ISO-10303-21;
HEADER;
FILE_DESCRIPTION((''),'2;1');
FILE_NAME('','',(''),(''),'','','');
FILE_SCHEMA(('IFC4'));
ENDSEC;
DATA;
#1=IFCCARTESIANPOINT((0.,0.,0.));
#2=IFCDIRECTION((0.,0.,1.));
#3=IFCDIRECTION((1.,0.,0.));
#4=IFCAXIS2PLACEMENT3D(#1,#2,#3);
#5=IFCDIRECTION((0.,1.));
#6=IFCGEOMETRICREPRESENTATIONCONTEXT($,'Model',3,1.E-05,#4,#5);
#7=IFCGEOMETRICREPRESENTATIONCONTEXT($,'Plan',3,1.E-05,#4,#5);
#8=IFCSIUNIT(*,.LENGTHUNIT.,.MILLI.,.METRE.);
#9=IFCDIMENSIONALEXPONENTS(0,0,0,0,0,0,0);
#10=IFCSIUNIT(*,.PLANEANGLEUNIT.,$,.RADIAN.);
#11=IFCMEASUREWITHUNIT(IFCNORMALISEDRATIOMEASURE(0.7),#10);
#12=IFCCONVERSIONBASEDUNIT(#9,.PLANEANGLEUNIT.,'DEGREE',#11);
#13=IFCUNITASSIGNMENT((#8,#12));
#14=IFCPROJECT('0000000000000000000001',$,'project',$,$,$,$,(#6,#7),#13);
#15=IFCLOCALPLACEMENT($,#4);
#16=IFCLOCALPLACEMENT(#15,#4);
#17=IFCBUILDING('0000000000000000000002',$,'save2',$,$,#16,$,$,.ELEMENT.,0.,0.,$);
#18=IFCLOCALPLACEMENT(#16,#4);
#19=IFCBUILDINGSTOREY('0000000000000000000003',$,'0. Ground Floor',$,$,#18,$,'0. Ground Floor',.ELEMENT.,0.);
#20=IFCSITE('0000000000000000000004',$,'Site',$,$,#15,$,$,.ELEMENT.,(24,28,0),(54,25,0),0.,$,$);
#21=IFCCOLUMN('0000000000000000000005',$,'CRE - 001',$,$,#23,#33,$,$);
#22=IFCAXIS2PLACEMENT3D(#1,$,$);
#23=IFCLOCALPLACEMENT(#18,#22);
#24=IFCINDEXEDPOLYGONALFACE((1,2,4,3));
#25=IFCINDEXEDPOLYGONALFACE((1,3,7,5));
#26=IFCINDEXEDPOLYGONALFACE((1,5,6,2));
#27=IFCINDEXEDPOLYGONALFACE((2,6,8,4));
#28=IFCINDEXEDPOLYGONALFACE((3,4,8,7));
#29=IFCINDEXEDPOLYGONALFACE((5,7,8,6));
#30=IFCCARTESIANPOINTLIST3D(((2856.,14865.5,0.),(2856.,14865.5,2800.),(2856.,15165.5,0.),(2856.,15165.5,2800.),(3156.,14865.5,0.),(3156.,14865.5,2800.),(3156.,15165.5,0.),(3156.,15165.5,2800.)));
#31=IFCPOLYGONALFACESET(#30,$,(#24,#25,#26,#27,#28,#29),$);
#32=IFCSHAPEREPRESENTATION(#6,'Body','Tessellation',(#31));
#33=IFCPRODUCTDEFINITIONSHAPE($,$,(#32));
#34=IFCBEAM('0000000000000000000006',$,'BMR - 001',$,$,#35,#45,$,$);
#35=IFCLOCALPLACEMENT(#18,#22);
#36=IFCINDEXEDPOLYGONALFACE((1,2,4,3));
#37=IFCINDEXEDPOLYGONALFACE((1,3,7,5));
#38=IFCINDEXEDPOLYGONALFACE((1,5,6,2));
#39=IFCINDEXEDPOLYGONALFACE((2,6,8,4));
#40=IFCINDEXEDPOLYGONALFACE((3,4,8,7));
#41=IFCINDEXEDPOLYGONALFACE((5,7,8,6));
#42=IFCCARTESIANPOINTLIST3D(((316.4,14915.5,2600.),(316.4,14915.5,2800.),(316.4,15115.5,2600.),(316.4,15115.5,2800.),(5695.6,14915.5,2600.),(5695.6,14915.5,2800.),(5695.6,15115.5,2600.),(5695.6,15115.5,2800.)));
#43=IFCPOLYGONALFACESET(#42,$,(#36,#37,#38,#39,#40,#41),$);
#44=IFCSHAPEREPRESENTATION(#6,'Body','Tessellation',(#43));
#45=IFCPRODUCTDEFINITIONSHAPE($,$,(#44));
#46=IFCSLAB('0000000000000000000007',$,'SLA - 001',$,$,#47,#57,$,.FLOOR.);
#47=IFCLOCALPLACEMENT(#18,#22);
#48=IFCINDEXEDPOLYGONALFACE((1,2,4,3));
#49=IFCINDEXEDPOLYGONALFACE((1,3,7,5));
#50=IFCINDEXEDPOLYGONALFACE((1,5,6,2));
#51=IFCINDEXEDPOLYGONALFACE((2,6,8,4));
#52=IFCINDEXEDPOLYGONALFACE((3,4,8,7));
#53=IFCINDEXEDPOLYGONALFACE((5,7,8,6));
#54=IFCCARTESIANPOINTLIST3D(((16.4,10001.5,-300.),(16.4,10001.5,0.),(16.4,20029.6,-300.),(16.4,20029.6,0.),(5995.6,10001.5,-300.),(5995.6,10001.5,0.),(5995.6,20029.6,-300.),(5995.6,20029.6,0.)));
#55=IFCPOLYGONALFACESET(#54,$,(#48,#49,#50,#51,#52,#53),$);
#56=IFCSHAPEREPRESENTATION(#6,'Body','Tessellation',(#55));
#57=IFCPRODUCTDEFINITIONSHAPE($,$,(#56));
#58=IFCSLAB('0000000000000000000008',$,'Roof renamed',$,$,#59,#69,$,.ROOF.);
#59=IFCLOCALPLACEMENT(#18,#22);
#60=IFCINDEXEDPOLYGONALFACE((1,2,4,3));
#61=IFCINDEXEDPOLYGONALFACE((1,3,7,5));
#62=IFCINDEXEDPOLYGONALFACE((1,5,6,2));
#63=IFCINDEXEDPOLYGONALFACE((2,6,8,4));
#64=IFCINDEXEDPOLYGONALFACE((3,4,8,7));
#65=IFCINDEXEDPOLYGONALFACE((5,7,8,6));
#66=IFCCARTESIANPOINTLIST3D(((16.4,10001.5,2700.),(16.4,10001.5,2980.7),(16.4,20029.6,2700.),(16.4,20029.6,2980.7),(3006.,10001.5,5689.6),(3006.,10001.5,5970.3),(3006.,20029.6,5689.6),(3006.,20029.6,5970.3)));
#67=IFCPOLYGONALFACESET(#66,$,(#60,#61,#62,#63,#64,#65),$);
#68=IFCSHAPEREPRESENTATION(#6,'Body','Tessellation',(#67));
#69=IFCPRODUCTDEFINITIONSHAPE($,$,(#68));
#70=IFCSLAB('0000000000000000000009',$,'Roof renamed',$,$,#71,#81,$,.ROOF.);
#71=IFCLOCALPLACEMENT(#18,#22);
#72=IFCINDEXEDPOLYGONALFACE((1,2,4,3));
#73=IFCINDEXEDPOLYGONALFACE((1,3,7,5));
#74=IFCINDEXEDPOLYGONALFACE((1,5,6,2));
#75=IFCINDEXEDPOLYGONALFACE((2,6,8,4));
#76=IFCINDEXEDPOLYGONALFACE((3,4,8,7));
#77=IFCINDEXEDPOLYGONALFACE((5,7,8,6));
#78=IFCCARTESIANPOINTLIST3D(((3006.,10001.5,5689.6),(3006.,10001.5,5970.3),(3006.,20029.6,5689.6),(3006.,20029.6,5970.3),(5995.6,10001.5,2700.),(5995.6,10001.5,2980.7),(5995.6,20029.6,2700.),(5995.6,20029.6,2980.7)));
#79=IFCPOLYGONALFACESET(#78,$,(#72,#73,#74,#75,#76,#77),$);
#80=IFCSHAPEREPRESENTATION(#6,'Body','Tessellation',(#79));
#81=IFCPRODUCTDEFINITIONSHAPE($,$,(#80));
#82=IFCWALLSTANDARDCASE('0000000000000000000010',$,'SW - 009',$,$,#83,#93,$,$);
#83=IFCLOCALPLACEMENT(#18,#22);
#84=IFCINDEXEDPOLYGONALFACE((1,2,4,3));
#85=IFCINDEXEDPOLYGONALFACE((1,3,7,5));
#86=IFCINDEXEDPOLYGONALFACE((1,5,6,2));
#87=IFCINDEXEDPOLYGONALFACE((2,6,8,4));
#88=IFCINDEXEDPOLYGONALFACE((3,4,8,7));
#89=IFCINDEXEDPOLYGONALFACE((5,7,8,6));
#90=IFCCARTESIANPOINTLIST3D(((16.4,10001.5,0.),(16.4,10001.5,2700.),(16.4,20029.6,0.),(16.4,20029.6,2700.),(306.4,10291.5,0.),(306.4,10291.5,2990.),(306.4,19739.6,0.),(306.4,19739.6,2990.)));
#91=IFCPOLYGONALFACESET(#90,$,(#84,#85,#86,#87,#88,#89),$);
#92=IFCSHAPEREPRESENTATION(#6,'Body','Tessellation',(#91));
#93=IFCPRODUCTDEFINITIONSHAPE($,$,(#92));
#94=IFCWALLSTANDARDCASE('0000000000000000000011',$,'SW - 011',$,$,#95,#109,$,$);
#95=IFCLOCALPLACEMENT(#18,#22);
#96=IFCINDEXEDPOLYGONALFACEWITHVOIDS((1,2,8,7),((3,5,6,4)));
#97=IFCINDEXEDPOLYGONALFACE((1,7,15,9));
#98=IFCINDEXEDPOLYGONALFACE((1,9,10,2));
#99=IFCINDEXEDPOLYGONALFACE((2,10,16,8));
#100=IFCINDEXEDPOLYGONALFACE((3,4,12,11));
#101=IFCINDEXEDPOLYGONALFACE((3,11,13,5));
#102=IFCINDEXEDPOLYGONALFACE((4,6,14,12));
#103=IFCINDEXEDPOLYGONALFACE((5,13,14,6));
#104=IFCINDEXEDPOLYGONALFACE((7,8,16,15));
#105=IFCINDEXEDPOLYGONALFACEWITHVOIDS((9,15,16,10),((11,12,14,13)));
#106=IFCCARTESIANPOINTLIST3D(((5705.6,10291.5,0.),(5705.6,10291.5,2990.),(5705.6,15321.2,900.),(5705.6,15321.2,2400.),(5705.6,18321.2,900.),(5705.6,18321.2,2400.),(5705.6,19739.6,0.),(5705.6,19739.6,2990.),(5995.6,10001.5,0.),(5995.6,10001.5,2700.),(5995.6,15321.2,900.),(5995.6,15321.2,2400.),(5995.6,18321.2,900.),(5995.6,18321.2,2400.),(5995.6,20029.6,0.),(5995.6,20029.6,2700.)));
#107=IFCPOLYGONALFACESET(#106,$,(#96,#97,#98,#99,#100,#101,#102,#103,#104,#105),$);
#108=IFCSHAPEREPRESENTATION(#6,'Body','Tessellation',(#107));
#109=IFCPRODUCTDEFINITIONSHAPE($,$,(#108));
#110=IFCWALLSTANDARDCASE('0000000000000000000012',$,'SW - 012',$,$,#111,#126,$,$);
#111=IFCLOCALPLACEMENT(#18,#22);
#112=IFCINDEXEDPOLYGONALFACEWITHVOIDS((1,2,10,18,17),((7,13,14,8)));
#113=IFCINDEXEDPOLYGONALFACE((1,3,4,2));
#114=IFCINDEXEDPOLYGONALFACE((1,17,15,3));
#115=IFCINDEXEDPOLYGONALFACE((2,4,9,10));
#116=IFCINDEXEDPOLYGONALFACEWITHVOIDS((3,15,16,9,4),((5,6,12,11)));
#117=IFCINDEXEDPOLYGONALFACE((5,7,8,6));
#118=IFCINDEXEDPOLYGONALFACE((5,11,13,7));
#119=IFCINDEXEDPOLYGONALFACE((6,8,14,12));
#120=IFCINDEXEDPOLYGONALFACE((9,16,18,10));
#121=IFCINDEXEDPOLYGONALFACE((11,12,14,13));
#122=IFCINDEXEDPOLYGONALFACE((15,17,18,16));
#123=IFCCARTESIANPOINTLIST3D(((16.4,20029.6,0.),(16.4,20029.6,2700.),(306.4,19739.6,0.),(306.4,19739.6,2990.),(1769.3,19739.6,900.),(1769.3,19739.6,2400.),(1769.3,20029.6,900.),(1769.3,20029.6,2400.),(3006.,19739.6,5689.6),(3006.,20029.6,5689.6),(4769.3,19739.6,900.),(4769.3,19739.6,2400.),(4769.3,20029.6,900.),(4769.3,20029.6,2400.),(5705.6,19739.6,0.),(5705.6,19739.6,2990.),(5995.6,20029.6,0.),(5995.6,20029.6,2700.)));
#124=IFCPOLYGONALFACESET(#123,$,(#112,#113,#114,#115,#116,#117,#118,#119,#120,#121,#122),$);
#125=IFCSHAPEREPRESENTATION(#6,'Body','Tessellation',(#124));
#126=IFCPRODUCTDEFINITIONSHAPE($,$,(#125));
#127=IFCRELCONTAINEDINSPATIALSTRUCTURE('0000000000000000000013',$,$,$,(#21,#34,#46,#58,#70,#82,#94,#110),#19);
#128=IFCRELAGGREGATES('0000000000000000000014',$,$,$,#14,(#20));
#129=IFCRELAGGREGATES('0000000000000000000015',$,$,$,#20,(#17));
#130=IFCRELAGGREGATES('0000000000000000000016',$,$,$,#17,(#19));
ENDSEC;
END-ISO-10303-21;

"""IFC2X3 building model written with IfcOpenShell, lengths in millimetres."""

from ifc_helpers import new_model, entity, si_unit, converted_unit, direction, frame, frame_2d, origin_with_axes, origin_2d_with_axis, place, context, project, spatial, polyline, rectangle, outline, extrude, clip, halfspace, bounded_halfspace, element, save


model = new_model("IFC2X3")

# Units and contexts
model_context_1 = context("Model", 3, precision=1e-05, world=origin_with_axes(), true_north=direction((0.0, 1.0)))
model_context_2 = context("Model", 3, precision=1e-05, world=origin_with_axes(), true_north=direction((0.0, 1.0)))
plan_context = context("Plan", 3, precision=1e-05, world=origin_with_axes(), true_north=direction((0.0, 1.0)))
ifc_project = project(units=[si_unit("LENGTHUNIT", "METRE", prefix="MILLI"), converted_unit("PLANEANGLEUNIT", "DEGREE", entity("IfcNormalisedRatioMeasure", 0.7), si_unit("PLANEANGLEUNIT", "RADIAN"), dimensions=[0, 0, 0, 0, 0, 0, 0])], contexts=[model_context_2, plan_context])

# Site, building, storey
site_placement = place(None, origin_with_axes())
site = spatial("IfcSite", under=ifc_project, at=site_placement, Name="Site", CompositionType="ELEMENT", RefLatitude=(24, 28, 0), RefLongitude=(54, 25, 0), RefElevation=0.0)
building_placement = place(site_placement, origin_with_axes())
building = spatial("IfcBuilding", under=site, at=building_placement, Name="save2", CompositionType="ELEMENT", ElevationOfRefHeight=0.0, ElevationOfTerrain=0.0)
storey_placement = place(building_placement, origin_with_axes())
storey = spatial("IfcBuildingStorey", under=building, at=storey_placement, Name="0. Ground Floor", LongName="0. Ground Floor", CompositionType="ELEMENT", Elevation=0.0)

# Column
column_placement = place(storey_placement, frame((3006.0, 15015.5, 0.0), z_axis=(0.0, 0.0, 1.0), x_axis=(1.0, 0.0, 0.0)))
element("IfcColumn", 1, at=column_placement, inside=storey, Name="CRE - 001", context=model_context_2, shape_type="SweptSolid", body=[
    extrude(rectangle(XDim=300.0, YDim=300.0, at=origin_2d_with_axis()), origin_with_axes(), (0.0, 0.0, 1.0), 2800.0),
])

# Beam
beam_placement = place(storey_placement, frame((316.4, 15015.5, 2800.0), z_axis=(0.0, 0.0, 1.0), x_axis=(0.0, -1.0, 0.0)))
element("IfcBeam", 2, at=beam_placement, inside=storey, Name="BMR - 001", context=model_context_2, shape_type="SweptSolid", body=[
    extrude(rectangle(XDim=200.0, YDim=200.0, at=frame_2d((-100.0, 0.0), x_axis=(1.0, 0.0))), frame((0.0, 0.0, 0.0), z_axis=(0.0, 1.0, 0.0), x_axis=(0.0, 0.0, 1.0)), (0.0, 0.0, 1.0), 5379.1),
])

# Slabs
slab_1_placement = place(storey_placement, frame((16.4, 20029.6, -300.0), z_axis=(0.0, 0.0, 1.0), x_axis=(1.0, 0.0, 0.0)))
element("IfcSlab", 3, at=slab_1_placement, inside=storey, Name="SLA - 001", PredefinedType="FLOOR", context=model_context_2, shape_type="SweptSolid", body=[
    extrude(outline(polyline([(0.0, 0.0), (5979.1, 0.0), (5979.1, -10028.0), (0.0, -10028.0)])), origin_with_axes(), (0.0, 0.0, 1.0), 300.0),
])
slab_2_placement = place(storey_placement, frame((16.4, 20029.6, 2700.0), z_axis=(-0.707107, 0.0, 0.707107), x_axis=(0.0, -1.0, 0.0)))
element("IfcSlab", 4, at=slab_2_placement, inside=storey, Name="Roof renamed", PredefinedType="ROOF", context=model_context_2, shape_type="SweptSolid", body=[
    extrude(outline(polyline([(0.0, 0.0), (0.0, 4227.9), (10028.0, 4227.9), (10028.0, 0.0)])), origin_with_axes(), (0.0, 0.707107, 0.707107), 280.7),
])
slab_3_placement = place(storey_placement, frame((5995.6, 10001.5, 2700.0), z_axis=(0.707107, 0.0, 0.707107), x_axis=(0.0, 1.0, 0.0)))
element("IfcSlab", 5, at=slab_3_placement, inside=storey, Name="Roof renamed", PredefinedType="ROOF", context=model_context_2, shape_type="SweptSolid", body=[
    extrude(outline(polyline([(0.0, 0.0), (10028.0, 0.0), (10028.0, 4227.9), (0.0, 4227.9)])), origin_with_axes(), (0.0, 0.707107, 0.707107), 280.7),
])

# Wall
wall_1_placement = place(storey_placement, frame((16.4, 20029.6, 0.0), z_axis=(0.0, 0.0, 1.0), x_axis=(0.0, -1.0, 0.0)))
element("IfcWallStandardCase", 6, at=wall_1_placement, inside=storey, Name="SW - 009", context=model_context_2, shape_type="Clipping", body=[
    clip(extrude(outline(polyline([(0.0, 0.0), (10028.0, 0.0), (9738.0, 290.0), (290.0, 290.0)])), origin_with_axes(), (0.0, 0.0, 1.0), 6000.0), halfspace(frame((0.0, -1350.0, 1350.0), z_axis=(0.0, 0.707107, -0.707107), x_axis=(0.0, 0.707107, 0.707107)), True)),
])

# Walls, openings
wall_2_placement = place(storey_placement, frame((5995.6, 10001.5, 0.0), z_axis=(0.0, 0.0, 1.0), x_axis=(0.0, 1.0, 0.0)))
wall_2 = element("IfcWallStandardCase", 7, at=wall_2_placement, inside=storey, Name="SW - 011", context=model_context_2, shape_type="Clipping", body=[
    clip(extrude(outline(polyline([(0.0, 0.0), (10028.0, 0.0), (9738.0, 290.0), (290.0, 290.0)])), origin_with_axes(), (0.0, 0.0, 1.0), 6000.0), halfspace(frame((0.0, -1350.0, 1350.0), z_axis=(0.0, 0.707107, -0.707107), x_axis=(0.0, 0.707107, 0.707107)), True)),
])
opening_1_placement = place(wall_2_placement, frame((6819.7, 0.0, 900.0), z_axis=(0.0, 0.0, 1.0), x_axis=(1.0, 0.0, 0.0)))
element("IfcOpeningElement", 8, at=opening_1_placement, cuts=wall_2, ObjectType="Opening", context=model_context_2, shape_type="SweptSolid", body=[
    extrude(rectangle(XDim=3000.0, YDim=1500.0, at=frame_2d((0.0, 750.0), x_axis=(1.0, 0.0))), frame((0.0, 0.0, 0.0), z_axis=(0.0, 1.0, 0.0), x_axis=(-1.0, 0.0, 0.0)), (0.0, 0.0, 1.0), 290.0),
])
wall_3_placement = place(storey_placement, frame((5995.6, 20029.6, 0.0), z_axis=(0.0, 0.0, 1.0), x_axis=(-1.0, 0.0, 0.0)))
wall_3 = element("IfcWallStandardCase", 9, at=wall_3_placement, inside=storey, Name="SW - 012", context=model_context_2, shape_type="Clipping", body=[
    clip(clip(extrude(outline(polyline([(0.0, 0.0), (5979.1, 0.0), (5689.1, 290.0), (290.0, 290.0)])), origin_with_axes(), (0.0, 0.0, 1.0), 6000.0), bounded_halfspace(frame((4339.6, 0.0, 4339.6), z_axis=(-0.707107, 0.0, -0.707107), x_axis=(0.0, 1.0, 0.0)), True, origin_with_axes(), polyline([(2989.6, -145.0), (2989.6, 435.0), (5989.1, 435.0), (5989.1, -145.0), (2989.6, -145.0)]))), bounded_halfspace(frame((-1350.0, 0.0, 1350.0), z_axis=(0.707107, 0.0, -0.707107), x_axis=(0.0, 1.0, 0.0)), True, origin_with_axes(), polyline([(2989.6, -145.0), (2989.6, 435.0), (-10.0, 435.0), (-10.0, -145.0), (2989.6, -145.0)]))),
])
placement_1 = place(None, origin_with_axes())
placement_2 = place(placement_1, origin_with_axes())
placement_3 = place(placement_2, origin_with_axes())
placement_4 = place(placement_3, frame((5995.6, 20029.6, 0.0), z_axis=(0.0, 0.0, 1.0), x_axis=(-1.0, 0.0, 0.0)))
opening_2_placement = place(placement_4, frame((2726.3, 0.0, 900.0), z_axis=(0.0, 0.0, 1.0), x_axis=(1.0, 0.0, 0.0)))
element("IfcOpeningElement", 10, at=opening_2_placement, cuts=wall_3, ObjectType="Opening", context=model_context_1, shape_type="SweptSolid", body=[
    extrude(rectangle(XDim=3000.0, YDim=1500.0, at=frame_2d((0.0, 750.0), x_axis=(1.0, 0.0))), frame((0.0, 0.0, 0.0), z_axis=(0.0, 1.0, 0.0), x_axis=(-1.0, 0.0, 0.0)), (0.0, 0.0, 1.0), 300.0),
])

save(model, "model.ifc")
